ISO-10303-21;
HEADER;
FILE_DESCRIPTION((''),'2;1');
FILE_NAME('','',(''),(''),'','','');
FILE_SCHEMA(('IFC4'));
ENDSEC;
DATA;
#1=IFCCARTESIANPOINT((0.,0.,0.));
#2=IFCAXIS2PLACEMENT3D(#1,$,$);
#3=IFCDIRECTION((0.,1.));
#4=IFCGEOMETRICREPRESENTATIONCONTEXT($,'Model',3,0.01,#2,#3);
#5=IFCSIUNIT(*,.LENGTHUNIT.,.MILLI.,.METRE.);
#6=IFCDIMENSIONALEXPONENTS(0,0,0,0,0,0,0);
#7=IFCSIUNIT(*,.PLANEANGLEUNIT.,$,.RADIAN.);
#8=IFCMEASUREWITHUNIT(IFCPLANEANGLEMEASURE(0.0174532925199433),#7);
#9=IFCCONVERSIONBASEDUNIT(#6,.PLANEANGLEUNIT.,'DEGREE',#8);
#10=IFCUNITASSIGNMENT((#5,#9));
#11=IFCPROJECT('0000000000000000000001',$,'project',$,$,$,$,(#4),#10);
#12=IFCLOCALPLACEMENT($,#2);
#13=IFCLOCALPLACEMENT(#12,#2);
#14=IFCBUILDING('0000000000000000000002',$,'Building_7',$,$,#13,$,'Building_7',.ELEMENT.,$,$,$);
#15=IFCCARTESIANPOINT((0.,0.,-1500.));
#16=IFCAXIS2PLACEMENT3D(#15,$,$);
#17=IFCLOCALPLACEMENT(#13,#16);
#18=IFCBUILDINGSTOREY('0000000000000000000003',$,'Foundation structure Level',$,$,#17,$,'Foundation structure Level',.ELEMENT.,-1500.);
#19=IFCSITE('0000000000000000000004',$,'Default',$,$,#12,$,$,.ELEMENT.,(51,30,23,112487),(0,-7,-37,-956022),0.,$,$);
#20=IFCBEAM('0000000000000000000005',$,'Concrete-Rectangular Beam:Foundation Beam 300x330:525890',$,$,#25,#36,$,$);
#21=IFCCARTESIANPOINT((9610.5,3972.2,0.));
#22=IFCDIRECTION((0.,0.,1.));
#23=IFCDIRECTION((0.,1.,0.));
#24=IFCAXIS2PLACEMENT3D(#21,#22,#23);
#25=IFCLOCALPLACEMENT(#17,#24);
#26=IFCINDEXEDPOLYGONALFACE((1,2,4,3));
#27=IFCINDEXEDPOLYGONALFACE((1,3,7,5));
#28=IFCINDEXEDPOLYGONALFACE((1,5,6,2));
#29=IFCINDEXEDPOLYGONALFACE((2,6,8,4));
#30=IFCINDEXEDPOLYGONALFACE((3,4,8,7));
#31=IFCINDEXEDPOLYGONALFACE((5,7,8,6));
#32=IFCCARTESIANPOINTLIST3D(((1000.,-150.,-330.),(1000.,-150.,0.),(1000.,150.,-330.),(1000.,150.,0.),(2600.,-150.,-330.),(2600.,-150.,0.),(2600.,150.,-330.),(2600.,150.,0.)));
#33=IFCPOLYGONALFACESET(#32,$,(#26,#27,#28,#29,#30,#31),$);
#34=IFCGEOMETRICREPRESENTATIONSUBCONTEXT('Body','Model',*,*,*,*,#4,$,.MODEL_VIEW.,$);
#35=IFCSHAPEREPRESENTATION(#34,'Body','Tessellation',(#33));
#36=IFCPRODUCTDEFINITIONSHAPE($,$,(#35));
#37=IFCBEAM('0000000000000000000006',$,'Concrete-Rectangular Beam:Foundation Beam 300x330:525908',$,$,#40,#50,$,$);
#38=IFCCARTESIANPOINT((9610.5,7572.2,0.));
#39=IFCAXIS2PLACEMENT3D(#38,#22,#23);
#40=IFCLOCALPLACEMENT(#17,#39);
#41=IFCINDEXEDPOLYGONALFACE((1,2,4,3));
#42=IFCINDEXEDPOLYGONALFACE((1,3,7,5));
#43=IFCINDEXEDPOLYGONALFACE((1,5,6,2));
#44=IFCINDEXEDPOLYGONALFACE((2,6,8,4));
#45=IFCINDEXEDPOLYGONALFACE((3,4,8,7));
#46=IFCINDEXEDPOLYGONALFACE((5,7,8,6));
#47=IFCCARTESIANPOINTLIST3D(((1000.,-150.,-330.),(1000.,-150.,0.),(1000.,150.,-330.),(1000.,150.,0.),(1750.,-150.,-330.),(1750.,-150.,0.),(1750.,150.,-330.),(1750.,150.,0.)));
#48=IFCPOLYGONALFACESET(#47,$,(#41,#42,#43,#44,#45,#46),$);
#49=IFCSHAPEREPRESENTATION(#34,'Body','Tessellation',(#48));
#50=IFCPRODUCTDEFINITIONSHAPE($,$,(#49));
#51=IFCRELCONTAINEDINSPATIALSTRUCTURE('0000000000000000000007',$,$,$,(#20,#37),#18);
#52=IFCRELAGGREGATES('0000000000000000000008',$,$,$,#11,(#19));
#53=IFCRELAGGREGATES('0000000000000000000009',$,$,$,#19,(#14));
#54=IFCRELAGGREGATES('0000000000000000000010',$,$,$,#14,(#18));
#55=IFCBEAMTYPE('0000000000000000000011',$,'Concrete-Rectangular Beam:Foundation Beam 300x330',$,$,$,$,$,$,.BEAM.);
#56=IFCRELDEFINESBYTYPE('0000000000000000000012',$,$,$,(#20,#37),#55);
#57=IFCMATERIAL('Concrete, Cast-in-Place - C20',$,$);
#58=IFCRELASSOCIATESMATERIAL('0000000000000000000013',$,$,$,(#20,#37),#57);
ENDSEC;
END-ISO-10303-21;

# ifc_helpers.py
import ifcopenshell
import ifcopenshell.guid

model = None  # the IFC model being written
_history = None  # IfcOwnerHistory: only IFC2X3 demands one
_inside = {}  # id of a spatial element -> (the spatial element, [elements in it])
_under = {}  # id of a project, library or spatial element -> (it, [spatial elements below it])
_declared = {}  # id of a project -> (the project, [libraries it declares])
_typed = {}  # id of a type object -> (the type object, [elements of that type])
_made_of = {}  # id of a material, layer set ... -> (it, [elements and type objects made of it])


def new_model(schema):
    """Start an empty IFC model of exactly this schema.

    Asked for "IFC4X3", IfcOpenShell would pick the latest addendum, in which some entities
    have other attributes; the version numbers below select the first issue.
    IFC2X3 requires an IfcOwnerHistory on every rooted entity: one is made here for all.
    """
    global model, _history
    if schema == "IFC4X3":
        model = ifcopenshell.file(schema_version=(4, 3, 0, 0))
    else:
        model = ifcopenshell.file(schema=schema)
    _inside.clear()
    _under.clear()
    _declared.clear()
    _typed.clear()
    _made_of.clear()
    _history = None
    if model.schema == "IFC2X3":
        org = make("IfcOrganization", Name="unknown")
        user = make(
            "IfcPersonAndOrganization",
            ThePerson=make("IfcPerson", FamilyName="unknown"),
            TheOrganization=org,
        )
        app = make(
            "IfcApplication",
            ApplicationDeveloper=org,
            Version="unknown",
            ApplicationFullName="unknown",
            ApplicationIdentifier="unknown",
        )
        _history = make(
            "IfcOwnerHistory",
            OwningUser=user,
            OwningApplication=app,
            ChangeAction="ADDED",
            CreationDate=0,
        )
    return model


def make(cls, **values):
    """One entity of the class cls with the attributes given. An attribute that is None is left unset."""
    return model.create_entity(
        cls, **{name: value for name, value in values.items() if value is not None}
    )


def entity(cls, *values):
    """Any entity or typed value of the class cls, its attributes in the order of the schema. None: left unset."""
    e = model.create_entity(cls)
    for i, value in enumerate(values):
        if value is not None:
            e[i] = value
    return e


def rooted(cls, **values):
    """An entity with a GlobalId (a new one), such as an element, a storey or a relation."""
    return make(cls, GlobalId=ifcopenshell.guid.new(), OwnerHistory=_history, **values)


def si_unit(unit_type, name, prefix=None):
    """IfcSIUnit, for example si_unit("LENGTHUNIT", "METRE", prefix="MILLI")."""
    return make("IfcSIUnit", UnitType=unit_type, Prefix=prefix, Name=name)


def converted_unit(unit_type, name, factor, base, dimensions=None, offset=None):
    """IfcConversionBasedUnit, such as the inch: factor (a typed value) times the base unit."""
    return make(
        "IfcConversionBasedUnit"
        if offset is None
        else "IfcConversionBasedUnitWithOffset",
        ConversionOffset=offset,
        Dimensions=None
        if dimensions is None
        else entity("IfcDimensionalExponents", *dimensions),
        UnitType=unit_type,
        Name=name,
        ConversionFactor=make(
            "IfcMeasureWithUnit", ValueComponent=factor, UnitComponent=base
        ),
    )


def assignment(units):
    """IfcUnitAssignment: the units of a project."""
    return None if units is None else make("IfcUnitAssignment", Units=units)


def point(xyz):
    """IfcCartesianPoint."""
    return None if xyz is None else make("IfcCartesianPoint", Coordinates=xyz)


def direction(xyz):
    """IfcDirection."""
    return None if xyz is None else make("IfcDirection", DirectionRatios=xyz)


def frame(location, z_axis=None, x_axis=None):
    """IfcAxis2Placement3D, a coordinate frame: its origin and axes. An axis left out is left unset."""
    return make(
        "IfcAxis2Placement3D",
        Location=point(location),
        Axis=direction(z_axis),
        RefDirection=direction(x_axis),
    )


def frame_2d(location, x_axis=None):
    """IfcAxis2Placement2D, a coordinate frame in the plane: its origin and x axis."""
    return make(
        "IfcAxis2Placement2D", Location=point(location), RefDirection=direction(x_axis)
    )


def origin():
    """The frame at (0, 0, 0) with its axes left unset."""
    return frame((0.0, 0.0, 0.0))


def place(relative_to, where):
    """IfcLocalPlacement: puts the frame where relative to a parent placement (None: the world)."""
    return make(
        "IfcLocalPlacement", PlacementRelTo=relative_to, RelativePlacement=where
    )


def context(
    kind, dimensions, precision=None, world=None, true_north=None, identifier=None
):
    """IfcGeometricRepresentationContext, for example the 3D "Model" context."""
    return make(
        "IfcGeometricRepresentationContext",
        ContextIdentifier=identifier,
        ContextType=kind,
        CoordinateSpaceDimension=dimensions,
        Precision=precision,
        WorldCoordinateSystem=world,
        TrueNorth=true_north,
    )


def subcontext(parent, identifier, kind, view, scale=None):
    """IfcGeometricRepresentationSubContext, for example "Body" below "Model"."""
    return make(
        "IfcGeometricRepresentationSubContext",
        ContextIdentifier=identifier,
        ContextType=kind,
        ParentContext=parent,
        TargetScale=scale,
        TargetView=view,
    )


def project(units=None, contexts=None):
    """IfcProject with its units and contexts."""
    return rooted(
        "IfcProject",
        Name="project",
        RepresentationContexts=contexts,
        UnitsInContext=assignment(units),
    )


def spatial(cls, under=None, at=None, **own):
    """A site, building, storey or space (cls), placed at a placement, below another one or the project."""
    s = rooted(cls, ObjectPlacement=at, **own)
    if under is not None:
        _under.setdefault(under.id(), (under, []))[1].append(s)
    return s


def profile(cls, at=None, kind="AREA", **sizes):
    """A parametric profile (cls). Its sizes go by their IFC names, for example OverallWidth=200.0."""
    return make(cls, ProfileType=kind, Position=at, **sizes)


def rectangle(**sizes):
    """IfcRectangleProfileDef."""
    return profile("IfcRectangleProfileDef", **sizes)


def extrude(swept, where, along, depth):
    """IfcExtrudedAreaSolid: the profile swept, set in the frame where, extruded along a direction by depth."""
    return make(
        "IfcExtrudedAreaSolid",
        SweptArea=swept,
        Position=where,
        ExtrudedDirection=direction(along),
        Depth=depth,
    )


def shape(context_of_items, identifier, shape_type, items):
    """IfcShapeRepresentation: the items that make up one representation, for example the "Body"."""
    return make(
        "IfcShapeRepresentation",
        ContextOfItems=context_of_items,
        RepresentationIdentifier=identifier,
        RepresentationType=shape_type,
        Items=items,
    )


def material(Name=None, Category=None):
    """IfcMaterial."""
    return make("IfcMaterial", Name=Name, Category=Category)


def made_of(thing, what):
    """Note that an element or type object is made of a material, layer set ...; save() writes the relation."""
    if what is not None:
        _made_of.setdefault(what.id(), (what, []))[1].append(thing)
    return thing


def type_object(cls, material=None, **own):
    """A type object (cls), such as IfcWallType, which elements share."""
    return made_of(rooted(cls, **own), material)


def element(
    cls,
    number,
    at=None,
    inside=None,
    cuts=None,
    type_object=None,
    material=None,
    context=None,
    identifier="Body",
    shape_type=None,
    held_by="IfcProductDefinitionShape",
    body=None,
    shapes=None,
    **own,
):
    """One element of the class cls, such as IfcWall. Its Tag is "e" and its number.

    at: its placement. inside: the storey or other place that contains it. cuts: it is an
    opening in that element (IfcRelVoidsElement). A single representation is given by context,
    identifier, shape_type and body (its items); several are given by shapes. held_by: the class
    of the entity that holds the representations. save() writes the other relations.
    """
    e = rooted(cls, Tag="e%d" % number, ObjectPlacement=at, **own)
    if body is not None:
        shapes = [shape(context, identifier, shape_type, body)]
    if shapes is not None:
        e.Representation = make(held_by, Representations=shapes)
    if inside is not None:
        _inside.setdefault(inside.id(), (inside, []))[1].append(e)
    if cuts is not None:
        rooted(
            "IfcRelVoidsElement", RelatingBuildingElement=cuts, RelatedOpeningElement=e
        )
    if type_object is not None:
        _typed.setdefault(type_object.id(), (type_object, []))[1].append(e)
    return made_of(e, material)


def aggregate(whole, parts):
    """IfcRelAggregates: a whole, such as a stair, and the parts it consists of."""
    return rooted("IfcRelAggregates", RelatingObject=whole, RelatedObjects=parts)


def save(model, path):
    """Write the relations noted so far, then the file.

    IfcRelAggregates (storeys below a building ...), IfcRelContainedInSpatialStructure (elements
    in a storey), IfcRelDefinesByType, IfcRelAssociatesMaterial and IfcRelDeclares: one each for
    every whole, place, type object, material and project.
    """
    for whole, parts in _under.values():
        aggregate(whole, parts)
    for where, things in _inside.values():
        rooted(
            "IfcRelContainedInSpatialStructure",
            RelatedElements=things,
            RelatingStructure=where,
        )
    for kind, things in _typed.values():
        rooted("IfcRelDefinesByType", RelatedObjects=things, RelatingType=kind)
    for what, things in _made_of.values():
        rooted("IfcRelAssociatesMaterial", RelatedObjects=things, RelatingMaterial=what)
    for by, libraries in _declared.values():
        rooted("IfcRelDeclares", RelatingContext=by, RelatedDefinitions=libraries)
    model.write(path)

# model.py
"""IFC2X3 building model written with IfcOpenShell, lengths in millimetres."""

from ifc_helpers import new_model, entity, si_unit, converted_unit, direction, frame, frame_2d, origin, place, context, subcontext, project, spatial, rectangle, extrude, material, type_object, element, save


model = new_model("IFC2X3")

# Units and contexts
model_context = context("Model", 3, precision=0.01, world=origin(), true_north=direction((0.0, 1.0)))
body_context = subcontext(model_context, "Body", "Model", "MODEL_VIEW")
ifc_project = project(units=[si_unit("LENGTHUNIT", "METRE", prefix="MILLI"), converted_unit("PLANEANGLEUNIT", "DEGREE", entity("IfcPlaneAngleMeasure", 0.0174532925199433), si_unit("PLANEANGLEUNIT", "RADIAN"), dimensions=[0, 0, 0, 0, 0, 0, 0])], contexts=[model_context])

# Site, building, storey
site_placement = place(None, origin())
site = spatial("IfcSite", under=ifc_project, at=site_placement, Name="Default", CompositionType="ELEMENT", RefLatitude=(51, 30, 23, 112487), RefLongitude=(0, -7, -37, -956022), RefElevation=0.0)
building_placement = place(site_placement, origin())
building = spatial("IfcBuilding", under=site, at=building_placement, Name="Building_7", LongName="Building_7", CompositionType="ELEMENT")
storey_placement = place(building_placement, frame((0.0, 0.0, -1500.0)))
storey = spatial("IfcBuildingStorey", under=building, at=storey_placement, Name="Foundation structure Level", LongName="Foundation structure Level", CompositionType="ELEMENT", Elevation=-1500.0)

# Beams
ifc_material_1 = material(Name="Concrete, Cast-in-Place - C20")
beam_type = type_object("IfcBeamType", Name="Concrete-Rectangular Beam:Foundation Beam 300x330", PredefinedType="BEAM")
beam_1_placement = place(storey_placement, frame((9610.5, 3972.2, 0.0), z_axis=(0.0, 0.0, 1.0), x_axis=(0.0, 1.0, 0.0)))
element("IfcBeam", 1, at=beam_1_placement, inside=storey, type_object=beam_type, material=ifc_material_1, Name="Concrete-Rectangular Beam:Foundation Beam 300x330:525890", context=body_context, shape_type="SweptSolid", body=[
    extrude(rectangle(XDim=330.0, YDim=300.0, at=frame_2d((0.0, 0.0), x_axis=(1.0, 0.0))), frame((1000.0, 0.0, -165.0), z_axis=(1.0, 0.0, 0.0), x_axis=(0.0, 0.0, -1.0)), (0.0, 0.0, 1.0), 1600.0),
])
beam_2_placement = place(storey_placement, frame((9610.5, 7572.2, 0.0), z_axis=(0.0, 0.0, 1.0), x_axis=(0.0, 1.0, 0.0)))
element("IfcBeam", 2, at=beam_2_placement, inside=storey, type_object=beam_type, material=ifc_material_1, Name="Concrete-Rectangular Beam:Foundation Beam 300x330:525908", context=body_context, shape_type="SweptSolid", body=[
    extrude(rectangle(XDim=330.0, YDim=300.0, at=frame_2d((0.0, 0.0), x_axis=(1.0, 0.0))), frame((1000.0, 0.0, -165.0), z_axis=(1.0, 0.0, 0.0), x_axis=(0.0, 0.0, -1.0)), (0.0, 0.0, 1.0), 750.0),
])

save(model, "model.ifc")
